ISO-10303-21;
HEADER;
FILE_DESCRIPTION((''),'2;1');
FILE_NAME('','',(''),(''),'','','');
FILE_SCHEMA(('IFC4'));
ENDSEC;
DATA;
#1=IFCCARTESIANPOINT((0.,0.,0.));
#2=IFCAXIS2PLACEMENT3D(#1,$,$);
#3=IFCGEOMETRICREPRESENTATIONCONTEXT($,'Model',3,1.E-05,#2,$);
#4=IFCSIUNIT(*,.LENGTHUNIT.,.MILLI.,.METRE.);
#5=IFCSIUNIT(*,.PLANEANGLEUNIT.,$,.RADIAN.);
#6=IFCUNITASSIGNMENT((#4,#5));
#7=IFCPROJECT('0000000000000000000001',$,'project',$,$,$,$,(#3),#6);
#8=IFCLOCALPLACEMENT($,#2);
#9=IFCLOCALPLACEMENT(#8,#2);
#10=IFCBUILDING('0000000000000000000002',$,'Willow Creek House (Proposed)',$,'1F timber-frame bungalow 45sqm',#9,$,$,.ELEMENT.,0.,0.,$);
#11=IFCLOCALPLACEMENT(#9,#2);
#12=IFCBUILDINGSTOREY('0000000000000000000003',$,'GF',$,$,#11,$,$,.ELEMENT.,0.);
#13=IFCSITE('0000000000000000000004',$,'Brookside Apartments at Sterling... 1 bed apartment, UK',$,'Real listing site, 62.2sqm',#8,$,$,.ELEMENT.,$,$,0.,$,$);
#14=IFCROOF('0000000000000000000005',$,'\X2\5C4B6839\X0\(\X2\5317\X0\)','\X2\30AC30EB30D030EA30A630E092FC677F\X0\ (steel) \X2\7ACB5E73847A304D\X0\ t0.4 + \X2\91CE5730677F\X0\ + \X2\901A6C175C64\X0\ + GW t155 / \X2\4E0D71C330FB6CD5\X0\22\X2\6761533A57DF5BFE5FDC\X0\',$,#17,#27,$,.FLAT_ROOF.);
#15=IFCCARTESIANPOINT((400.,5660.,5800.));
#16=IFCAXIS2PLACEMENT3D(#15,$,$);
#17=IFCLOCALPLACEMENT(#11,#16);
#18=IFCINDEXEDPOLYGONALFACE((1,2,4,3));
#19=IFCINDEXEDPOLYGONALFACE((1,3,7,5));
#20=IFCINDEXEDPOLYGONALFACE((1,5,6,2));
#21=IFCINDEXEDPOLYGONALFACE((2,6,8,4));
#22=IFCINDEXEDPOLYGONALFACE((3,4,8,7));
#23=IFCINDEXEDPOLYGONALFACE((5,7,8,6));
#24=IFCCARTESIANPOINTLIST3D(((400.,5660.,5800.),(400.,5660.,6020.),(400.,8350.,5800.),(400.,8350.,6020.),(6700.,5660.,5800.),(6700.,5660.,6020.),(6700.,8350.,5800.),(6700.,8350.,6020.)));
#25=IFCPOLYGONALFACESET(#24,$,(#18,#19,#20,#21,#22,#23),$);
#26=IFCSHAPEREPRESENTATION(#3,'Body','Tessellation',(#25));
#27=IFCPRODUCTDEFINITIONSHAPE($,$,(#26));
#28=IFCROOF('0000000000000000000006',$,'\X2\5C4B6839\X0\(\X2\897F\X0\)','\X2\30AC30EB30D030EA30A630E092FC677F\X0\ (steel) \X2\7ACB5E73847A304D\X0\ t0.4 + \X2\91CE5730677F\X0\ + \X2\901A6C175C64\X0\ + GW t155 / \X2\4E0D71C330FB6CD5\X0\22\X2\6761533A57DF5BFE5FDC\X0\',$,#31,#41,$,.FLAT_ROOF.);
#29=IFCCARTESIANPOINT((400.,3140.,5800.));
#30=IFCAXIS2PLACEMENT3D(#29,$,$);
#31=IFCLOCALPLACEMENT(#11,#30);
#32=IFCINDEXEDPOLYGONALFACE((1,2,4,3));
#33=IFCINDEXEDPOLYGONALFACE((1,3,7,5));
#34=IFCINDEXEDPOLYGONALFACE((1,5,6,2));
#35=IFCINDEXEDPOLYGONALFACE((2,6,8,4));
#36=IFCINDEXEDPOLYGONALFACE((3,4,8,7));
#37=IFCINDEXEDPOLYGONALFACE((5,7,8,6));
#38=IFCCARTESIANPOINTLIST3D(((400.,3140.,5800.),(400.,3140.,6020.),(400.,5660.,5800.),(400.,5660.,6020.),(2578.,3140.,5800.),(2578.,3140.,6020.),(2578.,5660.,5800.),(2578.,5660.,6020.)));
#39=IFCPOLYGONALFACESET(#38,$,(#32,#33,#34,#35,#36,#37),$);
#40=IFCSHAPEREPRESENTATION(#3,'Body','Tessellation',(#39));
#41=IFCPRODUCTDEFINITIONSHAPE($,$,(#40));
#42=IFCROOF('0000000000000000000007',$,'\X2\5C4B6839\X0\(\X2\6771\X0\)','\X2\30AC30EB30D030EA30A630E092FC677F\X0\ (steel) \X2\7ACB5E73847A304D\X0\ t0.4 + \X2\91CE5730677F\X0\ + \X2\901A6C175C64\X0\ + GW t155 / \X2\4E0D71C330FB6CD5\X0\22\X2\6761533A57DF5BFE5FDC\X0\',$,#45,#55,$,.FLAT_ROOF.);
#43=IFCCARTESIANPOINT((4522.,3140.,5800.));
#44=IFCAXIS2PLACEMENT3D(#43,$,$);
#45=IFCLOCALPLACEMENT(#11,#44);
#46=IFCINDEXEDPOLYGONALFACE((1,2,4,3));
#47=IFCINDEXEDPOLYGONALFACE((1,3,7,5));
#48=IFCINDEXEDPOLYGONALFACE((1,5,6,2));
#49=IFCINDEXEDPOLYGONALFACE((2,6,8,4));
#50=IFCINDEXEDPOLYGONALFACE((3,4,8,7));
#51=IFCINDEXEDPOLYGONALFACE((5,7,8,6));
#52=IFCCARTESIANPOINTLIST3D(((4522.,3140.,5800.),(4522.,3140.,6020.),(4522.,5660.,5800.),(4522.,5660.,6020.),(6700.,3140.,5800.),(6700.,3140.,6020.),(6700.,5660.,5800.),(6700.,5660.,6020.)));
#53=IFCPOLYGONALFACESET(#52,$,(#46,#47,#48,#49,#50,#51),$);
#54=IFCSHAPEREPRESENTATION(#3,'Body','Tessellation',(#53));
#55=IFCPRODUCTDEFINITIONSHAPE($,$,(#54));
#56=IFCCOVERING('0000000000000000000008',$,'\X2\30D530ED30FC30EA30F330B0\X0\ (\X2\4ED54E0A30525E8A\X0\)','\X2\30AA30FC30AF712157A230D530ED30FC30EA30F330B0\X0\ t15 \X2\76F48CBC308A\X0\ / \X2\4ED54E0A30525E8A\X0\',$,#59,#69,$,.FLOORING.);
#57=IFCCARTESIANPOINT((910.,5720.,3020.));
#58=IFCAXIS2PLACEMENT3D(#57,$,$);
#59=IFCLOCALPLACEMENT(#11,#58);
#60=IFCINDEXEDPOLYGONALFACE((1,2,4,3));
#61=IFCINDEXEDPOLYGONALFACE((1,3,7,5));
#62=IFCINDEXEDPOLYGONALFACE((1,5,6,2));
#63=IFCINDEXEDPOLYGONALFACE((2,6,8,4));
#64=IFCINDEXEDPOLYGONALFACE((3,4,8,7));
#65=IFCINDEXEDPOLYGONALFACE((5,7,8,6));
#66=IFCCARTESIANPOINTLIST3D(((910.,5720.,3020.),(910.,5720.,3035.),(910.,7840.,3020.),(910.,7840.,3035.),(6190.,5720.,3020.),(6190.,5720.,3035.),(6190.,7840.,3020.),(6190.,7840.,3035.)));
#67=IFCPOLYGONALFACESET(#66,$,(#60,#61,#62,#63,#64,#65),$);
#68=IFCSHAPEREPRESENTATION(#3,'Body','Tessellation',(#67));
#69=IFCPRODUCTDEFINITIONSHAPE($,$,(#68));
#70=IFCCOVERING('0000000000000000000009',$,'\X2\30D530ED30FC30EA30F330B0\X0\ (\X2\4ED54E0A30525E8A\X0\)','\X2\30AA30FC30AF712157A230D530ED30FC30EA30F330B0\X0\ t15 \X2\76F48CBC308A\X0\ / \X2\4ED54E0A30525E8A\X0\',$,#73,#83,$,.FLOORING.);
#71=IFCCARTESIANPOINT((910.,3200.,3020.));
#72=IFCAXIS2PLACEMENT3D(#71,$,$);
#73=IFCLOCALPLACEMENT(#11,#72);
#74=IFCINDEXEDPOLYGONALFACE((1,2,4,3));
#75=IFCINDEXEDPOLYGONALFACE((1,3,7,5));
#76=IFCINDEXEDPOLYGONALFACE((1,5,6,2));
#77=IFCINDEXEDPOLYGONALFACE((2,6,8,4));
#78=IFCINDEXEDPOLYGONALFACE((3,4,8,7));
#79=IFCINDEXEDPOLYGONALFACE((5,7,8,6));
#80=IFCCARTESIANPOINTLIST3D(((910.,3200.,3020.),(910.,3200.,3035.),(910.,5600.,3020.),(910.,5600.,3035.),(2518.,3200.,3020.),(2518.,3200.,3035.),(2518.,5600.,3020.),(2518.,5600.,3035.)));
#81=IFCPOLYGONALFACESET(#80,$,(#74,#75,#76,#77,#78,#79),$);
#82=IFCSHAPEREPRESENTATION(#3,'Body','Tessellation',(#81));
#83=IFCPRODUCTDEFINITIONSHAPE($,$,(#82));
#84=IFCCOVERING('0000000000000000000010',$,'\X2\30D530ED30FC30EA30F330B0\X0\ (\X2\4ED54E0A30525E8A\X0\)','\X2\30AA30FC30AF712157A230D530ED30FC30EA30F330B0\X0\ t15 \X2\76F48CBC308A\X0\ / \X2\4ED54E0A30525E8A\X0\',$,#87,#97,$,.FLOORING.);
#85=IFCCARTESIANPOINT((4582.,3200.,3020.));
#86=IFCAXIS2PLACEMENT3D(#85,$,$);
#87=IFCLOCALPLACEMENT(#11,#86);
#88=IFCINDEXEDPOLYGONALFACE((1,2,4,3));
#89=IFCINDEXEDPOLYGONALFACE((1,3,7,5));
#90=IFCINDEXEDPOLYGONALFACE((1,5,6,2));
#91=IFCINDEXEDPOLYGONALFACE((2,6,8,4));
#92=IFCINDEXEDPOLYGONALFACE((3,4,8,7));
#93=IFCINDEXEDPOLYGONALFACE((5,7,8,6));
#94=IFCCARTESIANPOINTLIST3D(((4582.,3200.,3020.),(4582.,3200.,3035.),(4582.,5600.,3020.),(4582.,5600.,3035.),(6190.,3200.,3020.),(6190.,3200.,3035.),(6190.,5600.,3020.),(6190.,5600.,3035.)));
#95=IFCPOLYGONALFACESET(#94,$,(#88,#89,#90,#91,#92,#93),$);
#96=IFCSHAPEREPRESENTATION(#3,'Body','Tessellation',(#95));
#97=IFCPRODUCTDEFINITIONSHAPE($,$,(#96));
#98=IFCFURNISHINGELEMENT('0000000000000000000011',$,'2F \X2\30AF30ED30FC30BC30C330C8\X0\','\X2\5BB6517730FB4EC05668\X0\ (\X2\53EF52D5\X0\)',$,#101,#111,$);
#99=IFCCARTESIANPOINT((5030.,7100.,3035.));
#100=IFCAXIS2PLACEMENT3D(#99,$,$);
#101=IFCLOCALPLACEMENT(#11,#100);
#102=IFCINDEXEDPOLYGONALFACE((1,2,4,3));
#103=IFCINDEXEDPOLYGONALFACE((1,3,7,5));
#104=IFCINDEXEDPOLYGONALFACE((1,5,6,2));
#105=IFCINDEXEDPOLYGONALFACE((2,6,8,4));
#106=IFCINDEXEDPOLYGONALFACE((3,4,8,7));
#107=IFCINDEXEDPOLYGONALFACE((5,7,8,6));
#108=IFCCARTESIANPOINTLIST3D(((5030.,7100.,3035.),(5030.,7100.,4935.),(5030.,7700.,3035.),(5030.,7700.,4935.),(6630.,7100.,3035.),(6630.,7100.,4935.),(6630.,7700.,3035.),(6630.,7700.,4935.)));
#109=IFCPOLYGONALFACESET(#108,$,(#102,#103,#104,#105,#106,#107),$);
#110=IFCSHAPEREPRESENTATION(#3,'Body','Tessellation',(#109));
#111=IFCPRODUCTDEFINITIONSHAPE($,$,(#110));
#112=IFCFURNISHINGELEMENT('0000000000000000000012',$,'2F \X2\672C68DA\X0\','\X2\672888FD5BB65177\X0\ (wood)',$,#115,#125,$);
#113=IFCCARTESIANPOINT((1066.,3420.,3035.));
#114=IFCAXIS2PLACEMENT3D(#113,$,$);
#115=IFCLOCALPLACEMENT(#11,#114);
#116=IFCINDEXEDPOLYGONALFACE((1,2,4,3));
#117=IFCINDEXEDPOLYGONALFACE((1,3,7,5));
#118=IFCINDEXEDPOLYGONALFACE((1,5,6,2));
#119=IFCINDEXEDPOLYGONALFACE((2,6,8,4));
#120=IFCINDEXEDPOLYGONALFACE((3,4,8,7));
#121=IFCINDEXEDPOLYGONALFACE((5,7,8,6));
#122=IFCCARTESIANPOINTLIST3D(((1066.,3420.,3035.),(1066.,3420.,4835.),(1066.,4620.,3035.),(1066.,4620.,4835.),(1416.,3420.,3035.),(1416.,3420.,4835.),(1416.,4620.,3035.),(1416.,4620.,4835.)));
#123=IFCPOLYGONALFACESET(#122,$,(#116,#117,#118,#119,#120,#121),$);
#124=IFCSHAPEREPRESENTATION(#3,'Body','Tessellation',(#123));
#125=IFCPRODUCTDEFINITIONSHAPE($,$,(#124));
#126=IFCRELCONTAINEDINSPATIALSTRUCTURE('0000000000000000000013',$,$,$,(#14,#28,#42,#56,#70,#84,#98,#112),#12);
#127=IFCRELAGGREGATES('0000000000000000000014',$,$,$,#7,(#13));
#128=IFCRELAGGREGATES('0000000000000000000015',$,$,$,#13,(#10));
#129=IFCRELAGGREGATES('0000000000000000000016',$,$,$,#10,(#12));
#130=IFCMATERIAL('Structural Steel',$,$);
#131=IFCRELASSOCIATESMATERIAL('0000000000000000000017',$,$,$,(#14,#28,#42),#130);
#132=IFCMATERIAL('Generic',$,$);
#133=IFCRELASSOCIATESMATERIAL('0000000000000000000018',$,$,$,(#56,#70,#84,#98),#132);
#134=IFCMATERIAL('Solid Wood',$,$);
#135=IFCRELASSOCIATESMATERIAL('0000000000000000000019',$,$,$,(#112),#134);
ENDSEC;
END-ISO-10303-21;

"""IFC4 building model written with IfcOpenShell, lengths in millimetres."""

from ifc_helpers import new_model, si_unit, frame, frame_2d, origin, place, context, project, spatial, rectangle, extrude, material, element, save


model = new_model("IFC4")

# Units and contexts
model_context = context("Model", 3, precision=1e-05, world=origin())
ifc_project = project(units=[si_unit("LENGTHUNIT", "METRE", prefix="MILLI"), si_unit("PLANEANGLEUNIT", "RADIAN")], contexts=[model_context])

# Site, building, storey
site_placement = place(None, origin())
site = spatial("IfcSite", under=ifc_project, at=site_placement, Name="Brookside Apartments at Sterling... 1 bed apartment, UK", ObjectType="Real listing site, 62.2sqm", CompositionType="ELEMENT", RefElevation=0.0)
building_placement = place(site_placement, origin())
building = spatial("IfcBuilding", under=site, at=building_placement, Name="Willow Creek House (Proposed)", ObjectType="1F timber-frame bungalow 45sqm", CompositionType="ELEMENT", ElevationOfRefHeight=0.0, ElevationOfTerrain=0.0)
storey_placement = place(building_placement, origin())
storey = spatial("IfcBuildingStorey", under=building, at=storey_placement, Name="GF", CompositionType="ELEMENT", Elevation=0.0)

# Shared definitions
ifc_material_1 = material(Name="Solid Wood")

# Roofs
ifc_material_2 = material(Name="Structural Steel")
for number, where, name in (
    (1, (400.0, 5660.0, 5800.0), "屋根(北)"),
):
    element("IfcRoof", number, at=place(storey_placement, frame(where)), inside=storey, material=ifc_material_2, Name=name, Description="ガルバリウム鋼板 (steel) 立平葺き t0.4 + 野地板 + 通気層 + GW t155 / 不燃・法22条区域対応", PredefinedType="FLAT_ROOF", context=model_context, shape_type="SweptSolid", body=[
        extrude(rectangle(XDim=6300.0, YDim=2690.0, at=frame_2d((3150.0, 1345.0))), frame((400.0, 5660.0, 5800.0)), (0.0, 0.0, 1.0), 220.0),
    ])
roof_1_placement = place(storey_placement, frame((400.0, 3140.0, 5800.0)))
element("IfcRoof", 2, at=roof_1_placement, inside=storey, material=ifc_material_2, Name="屋根(西)", Description="ガルバリウム鋼板 (steel) 立平葺き t0.4 + 野地板 + 通気層 + GW t155 / 不燃・法22条区域対応", PredefinedType="FLAT_ROOF", context=model_context, shape_type="SweptSolid", body=[
    extrude(rectangle(XDim=2178.0, YDim=2520.0, at=frame_2d((1089.0, 1260.0))), frame((400.0, 3140.0, 5800.0)), (0.0, 0.0, 1.0), 220.0),
])
roof_2_placement = place(storey_placement, frame((4522.0, 3140.0, 5800.0)))
element("IfcRoof", 3, at=roof_2_placement, inside=storey, material=ifc_material_2, Name="屋根(東)", Description="ガルバリウム鋼板 (steel) 立平葺き t0.4 + 野地板 + 通気層 + GW t155 / 不燃・法22条区域対応", PredefinedType="FLAT_ROOF", context=model_context, shape_type="SweptSolid", body=[
    extrude(rectangle(XDim=2178.0, YDim=2520.0, at=frame_2d((1089.0, 1260.0))), frame((4522.0, 3140.0, 5800.0)), (0.0, 0.0, 1.0), 220.0),
])

# Coverings
ifc_material_3 = material(Name="Generic")
covering_1_placement = place(storey_placement, frame((910.0, 5720.0, 3020.0)))
element("IfcCovering", 4, at=covering_1_placement, inside=storey, material=ifc_material_3, Name="フローリング (仕上げ床)", Description="オーク無垢フローリング t15 直貼り / 仕上げ床", PredefinedType="FLOORING", context=model_context, shape_type="SweptSolid", body=[
    extrude(rectangle(XDim=5280.0, YDim=2120.0, at=frame_2d((2640.0, 1060.0))), frame((910.0, 5720.0, 3020.0)), (0.0, 0.0, 1.0), 15.0),
])
covering_2_placement = place(storey_placement, frame((910.0, 3200.0, 3020.0)))
element("IfcCovering", 5, at=covering_2_placement, inside=storey, material=ifc_material_3, Name="フローリング (仕上げ床)", Description="オーク無垢フローリング t15 直貼り / 仕上げ床", PredefinedType="FLOORING", context=model_context, shape_type="SweptSolid", body=[
    extrude(rectangle(XDim=1608.0, YDim=2400.0, at=frame_2d((804.0, 1200.0))), frame((910.0, 3200.0, 3020.0)), (0.0, 0.0, 1.0), 15.0),
])
covering_3_placement = place(storey_placement, frame((4582.0, 3200.0, 3020.0)))
element("IfcCovering", 6, at=covering_3_placement, inside=storey, material=ifc_material_3, Name="フローリング (仕上げ床)", Description="オーク無垢フローリング t15 直貼り / 仕上げ床", PredefinedType="FLOORING", context=model_context, shape_type="SweptSolid", body=[
    extrude(rectangle(XDim=1608.0, YDim=2400.0, at=frame_2d((804.0, 1200.0))), frame((4582.0, 3200.0, 3020.0)), (0.0, 0.0, 1.0), 15.0),
])

# Furnishing elements
furnishing_1_placement = place(storey_placement, frame((5030.0, 7100.0, 3035.0)))
element("IfcFurnishingElement", 7, at=furnishing_1_placement, inside=storey, material=ifc_material_3, Name="2F クローゼット", Description="家具・什器 (可動)", context=model_context, shape_type="SweptSolid", body=[
    extrude(rectangle(XDim=1600.0, YDim=600.0, at=frame_2d((800.0, 300.0))), frame((5030.0, 7100.0, 3035.0)), (0.0, 0.0, 1.0), 1900.0),
])
furnishing_2_placement = place(storey_placement, frame((1066.0, 3420.0, 3035.0)))
element("IfcFurnishingElement", 8, at=furnishing_2_placement, inside=storey, material=ifc_material_1, Name="2F 本棚", Description="木製家具 (wood)", context=model_context, shape_type="SweptSolid", body=[
    extrude(rectangle(XDim=350.0, YDim=1200.0, at=frame_2d((175.0, 600.0))), frame((1066.0, 3420.0, 3035.0)), (0.0, 0.0, 1.0), 1800.0),
])

save(model, "model.ifc")
